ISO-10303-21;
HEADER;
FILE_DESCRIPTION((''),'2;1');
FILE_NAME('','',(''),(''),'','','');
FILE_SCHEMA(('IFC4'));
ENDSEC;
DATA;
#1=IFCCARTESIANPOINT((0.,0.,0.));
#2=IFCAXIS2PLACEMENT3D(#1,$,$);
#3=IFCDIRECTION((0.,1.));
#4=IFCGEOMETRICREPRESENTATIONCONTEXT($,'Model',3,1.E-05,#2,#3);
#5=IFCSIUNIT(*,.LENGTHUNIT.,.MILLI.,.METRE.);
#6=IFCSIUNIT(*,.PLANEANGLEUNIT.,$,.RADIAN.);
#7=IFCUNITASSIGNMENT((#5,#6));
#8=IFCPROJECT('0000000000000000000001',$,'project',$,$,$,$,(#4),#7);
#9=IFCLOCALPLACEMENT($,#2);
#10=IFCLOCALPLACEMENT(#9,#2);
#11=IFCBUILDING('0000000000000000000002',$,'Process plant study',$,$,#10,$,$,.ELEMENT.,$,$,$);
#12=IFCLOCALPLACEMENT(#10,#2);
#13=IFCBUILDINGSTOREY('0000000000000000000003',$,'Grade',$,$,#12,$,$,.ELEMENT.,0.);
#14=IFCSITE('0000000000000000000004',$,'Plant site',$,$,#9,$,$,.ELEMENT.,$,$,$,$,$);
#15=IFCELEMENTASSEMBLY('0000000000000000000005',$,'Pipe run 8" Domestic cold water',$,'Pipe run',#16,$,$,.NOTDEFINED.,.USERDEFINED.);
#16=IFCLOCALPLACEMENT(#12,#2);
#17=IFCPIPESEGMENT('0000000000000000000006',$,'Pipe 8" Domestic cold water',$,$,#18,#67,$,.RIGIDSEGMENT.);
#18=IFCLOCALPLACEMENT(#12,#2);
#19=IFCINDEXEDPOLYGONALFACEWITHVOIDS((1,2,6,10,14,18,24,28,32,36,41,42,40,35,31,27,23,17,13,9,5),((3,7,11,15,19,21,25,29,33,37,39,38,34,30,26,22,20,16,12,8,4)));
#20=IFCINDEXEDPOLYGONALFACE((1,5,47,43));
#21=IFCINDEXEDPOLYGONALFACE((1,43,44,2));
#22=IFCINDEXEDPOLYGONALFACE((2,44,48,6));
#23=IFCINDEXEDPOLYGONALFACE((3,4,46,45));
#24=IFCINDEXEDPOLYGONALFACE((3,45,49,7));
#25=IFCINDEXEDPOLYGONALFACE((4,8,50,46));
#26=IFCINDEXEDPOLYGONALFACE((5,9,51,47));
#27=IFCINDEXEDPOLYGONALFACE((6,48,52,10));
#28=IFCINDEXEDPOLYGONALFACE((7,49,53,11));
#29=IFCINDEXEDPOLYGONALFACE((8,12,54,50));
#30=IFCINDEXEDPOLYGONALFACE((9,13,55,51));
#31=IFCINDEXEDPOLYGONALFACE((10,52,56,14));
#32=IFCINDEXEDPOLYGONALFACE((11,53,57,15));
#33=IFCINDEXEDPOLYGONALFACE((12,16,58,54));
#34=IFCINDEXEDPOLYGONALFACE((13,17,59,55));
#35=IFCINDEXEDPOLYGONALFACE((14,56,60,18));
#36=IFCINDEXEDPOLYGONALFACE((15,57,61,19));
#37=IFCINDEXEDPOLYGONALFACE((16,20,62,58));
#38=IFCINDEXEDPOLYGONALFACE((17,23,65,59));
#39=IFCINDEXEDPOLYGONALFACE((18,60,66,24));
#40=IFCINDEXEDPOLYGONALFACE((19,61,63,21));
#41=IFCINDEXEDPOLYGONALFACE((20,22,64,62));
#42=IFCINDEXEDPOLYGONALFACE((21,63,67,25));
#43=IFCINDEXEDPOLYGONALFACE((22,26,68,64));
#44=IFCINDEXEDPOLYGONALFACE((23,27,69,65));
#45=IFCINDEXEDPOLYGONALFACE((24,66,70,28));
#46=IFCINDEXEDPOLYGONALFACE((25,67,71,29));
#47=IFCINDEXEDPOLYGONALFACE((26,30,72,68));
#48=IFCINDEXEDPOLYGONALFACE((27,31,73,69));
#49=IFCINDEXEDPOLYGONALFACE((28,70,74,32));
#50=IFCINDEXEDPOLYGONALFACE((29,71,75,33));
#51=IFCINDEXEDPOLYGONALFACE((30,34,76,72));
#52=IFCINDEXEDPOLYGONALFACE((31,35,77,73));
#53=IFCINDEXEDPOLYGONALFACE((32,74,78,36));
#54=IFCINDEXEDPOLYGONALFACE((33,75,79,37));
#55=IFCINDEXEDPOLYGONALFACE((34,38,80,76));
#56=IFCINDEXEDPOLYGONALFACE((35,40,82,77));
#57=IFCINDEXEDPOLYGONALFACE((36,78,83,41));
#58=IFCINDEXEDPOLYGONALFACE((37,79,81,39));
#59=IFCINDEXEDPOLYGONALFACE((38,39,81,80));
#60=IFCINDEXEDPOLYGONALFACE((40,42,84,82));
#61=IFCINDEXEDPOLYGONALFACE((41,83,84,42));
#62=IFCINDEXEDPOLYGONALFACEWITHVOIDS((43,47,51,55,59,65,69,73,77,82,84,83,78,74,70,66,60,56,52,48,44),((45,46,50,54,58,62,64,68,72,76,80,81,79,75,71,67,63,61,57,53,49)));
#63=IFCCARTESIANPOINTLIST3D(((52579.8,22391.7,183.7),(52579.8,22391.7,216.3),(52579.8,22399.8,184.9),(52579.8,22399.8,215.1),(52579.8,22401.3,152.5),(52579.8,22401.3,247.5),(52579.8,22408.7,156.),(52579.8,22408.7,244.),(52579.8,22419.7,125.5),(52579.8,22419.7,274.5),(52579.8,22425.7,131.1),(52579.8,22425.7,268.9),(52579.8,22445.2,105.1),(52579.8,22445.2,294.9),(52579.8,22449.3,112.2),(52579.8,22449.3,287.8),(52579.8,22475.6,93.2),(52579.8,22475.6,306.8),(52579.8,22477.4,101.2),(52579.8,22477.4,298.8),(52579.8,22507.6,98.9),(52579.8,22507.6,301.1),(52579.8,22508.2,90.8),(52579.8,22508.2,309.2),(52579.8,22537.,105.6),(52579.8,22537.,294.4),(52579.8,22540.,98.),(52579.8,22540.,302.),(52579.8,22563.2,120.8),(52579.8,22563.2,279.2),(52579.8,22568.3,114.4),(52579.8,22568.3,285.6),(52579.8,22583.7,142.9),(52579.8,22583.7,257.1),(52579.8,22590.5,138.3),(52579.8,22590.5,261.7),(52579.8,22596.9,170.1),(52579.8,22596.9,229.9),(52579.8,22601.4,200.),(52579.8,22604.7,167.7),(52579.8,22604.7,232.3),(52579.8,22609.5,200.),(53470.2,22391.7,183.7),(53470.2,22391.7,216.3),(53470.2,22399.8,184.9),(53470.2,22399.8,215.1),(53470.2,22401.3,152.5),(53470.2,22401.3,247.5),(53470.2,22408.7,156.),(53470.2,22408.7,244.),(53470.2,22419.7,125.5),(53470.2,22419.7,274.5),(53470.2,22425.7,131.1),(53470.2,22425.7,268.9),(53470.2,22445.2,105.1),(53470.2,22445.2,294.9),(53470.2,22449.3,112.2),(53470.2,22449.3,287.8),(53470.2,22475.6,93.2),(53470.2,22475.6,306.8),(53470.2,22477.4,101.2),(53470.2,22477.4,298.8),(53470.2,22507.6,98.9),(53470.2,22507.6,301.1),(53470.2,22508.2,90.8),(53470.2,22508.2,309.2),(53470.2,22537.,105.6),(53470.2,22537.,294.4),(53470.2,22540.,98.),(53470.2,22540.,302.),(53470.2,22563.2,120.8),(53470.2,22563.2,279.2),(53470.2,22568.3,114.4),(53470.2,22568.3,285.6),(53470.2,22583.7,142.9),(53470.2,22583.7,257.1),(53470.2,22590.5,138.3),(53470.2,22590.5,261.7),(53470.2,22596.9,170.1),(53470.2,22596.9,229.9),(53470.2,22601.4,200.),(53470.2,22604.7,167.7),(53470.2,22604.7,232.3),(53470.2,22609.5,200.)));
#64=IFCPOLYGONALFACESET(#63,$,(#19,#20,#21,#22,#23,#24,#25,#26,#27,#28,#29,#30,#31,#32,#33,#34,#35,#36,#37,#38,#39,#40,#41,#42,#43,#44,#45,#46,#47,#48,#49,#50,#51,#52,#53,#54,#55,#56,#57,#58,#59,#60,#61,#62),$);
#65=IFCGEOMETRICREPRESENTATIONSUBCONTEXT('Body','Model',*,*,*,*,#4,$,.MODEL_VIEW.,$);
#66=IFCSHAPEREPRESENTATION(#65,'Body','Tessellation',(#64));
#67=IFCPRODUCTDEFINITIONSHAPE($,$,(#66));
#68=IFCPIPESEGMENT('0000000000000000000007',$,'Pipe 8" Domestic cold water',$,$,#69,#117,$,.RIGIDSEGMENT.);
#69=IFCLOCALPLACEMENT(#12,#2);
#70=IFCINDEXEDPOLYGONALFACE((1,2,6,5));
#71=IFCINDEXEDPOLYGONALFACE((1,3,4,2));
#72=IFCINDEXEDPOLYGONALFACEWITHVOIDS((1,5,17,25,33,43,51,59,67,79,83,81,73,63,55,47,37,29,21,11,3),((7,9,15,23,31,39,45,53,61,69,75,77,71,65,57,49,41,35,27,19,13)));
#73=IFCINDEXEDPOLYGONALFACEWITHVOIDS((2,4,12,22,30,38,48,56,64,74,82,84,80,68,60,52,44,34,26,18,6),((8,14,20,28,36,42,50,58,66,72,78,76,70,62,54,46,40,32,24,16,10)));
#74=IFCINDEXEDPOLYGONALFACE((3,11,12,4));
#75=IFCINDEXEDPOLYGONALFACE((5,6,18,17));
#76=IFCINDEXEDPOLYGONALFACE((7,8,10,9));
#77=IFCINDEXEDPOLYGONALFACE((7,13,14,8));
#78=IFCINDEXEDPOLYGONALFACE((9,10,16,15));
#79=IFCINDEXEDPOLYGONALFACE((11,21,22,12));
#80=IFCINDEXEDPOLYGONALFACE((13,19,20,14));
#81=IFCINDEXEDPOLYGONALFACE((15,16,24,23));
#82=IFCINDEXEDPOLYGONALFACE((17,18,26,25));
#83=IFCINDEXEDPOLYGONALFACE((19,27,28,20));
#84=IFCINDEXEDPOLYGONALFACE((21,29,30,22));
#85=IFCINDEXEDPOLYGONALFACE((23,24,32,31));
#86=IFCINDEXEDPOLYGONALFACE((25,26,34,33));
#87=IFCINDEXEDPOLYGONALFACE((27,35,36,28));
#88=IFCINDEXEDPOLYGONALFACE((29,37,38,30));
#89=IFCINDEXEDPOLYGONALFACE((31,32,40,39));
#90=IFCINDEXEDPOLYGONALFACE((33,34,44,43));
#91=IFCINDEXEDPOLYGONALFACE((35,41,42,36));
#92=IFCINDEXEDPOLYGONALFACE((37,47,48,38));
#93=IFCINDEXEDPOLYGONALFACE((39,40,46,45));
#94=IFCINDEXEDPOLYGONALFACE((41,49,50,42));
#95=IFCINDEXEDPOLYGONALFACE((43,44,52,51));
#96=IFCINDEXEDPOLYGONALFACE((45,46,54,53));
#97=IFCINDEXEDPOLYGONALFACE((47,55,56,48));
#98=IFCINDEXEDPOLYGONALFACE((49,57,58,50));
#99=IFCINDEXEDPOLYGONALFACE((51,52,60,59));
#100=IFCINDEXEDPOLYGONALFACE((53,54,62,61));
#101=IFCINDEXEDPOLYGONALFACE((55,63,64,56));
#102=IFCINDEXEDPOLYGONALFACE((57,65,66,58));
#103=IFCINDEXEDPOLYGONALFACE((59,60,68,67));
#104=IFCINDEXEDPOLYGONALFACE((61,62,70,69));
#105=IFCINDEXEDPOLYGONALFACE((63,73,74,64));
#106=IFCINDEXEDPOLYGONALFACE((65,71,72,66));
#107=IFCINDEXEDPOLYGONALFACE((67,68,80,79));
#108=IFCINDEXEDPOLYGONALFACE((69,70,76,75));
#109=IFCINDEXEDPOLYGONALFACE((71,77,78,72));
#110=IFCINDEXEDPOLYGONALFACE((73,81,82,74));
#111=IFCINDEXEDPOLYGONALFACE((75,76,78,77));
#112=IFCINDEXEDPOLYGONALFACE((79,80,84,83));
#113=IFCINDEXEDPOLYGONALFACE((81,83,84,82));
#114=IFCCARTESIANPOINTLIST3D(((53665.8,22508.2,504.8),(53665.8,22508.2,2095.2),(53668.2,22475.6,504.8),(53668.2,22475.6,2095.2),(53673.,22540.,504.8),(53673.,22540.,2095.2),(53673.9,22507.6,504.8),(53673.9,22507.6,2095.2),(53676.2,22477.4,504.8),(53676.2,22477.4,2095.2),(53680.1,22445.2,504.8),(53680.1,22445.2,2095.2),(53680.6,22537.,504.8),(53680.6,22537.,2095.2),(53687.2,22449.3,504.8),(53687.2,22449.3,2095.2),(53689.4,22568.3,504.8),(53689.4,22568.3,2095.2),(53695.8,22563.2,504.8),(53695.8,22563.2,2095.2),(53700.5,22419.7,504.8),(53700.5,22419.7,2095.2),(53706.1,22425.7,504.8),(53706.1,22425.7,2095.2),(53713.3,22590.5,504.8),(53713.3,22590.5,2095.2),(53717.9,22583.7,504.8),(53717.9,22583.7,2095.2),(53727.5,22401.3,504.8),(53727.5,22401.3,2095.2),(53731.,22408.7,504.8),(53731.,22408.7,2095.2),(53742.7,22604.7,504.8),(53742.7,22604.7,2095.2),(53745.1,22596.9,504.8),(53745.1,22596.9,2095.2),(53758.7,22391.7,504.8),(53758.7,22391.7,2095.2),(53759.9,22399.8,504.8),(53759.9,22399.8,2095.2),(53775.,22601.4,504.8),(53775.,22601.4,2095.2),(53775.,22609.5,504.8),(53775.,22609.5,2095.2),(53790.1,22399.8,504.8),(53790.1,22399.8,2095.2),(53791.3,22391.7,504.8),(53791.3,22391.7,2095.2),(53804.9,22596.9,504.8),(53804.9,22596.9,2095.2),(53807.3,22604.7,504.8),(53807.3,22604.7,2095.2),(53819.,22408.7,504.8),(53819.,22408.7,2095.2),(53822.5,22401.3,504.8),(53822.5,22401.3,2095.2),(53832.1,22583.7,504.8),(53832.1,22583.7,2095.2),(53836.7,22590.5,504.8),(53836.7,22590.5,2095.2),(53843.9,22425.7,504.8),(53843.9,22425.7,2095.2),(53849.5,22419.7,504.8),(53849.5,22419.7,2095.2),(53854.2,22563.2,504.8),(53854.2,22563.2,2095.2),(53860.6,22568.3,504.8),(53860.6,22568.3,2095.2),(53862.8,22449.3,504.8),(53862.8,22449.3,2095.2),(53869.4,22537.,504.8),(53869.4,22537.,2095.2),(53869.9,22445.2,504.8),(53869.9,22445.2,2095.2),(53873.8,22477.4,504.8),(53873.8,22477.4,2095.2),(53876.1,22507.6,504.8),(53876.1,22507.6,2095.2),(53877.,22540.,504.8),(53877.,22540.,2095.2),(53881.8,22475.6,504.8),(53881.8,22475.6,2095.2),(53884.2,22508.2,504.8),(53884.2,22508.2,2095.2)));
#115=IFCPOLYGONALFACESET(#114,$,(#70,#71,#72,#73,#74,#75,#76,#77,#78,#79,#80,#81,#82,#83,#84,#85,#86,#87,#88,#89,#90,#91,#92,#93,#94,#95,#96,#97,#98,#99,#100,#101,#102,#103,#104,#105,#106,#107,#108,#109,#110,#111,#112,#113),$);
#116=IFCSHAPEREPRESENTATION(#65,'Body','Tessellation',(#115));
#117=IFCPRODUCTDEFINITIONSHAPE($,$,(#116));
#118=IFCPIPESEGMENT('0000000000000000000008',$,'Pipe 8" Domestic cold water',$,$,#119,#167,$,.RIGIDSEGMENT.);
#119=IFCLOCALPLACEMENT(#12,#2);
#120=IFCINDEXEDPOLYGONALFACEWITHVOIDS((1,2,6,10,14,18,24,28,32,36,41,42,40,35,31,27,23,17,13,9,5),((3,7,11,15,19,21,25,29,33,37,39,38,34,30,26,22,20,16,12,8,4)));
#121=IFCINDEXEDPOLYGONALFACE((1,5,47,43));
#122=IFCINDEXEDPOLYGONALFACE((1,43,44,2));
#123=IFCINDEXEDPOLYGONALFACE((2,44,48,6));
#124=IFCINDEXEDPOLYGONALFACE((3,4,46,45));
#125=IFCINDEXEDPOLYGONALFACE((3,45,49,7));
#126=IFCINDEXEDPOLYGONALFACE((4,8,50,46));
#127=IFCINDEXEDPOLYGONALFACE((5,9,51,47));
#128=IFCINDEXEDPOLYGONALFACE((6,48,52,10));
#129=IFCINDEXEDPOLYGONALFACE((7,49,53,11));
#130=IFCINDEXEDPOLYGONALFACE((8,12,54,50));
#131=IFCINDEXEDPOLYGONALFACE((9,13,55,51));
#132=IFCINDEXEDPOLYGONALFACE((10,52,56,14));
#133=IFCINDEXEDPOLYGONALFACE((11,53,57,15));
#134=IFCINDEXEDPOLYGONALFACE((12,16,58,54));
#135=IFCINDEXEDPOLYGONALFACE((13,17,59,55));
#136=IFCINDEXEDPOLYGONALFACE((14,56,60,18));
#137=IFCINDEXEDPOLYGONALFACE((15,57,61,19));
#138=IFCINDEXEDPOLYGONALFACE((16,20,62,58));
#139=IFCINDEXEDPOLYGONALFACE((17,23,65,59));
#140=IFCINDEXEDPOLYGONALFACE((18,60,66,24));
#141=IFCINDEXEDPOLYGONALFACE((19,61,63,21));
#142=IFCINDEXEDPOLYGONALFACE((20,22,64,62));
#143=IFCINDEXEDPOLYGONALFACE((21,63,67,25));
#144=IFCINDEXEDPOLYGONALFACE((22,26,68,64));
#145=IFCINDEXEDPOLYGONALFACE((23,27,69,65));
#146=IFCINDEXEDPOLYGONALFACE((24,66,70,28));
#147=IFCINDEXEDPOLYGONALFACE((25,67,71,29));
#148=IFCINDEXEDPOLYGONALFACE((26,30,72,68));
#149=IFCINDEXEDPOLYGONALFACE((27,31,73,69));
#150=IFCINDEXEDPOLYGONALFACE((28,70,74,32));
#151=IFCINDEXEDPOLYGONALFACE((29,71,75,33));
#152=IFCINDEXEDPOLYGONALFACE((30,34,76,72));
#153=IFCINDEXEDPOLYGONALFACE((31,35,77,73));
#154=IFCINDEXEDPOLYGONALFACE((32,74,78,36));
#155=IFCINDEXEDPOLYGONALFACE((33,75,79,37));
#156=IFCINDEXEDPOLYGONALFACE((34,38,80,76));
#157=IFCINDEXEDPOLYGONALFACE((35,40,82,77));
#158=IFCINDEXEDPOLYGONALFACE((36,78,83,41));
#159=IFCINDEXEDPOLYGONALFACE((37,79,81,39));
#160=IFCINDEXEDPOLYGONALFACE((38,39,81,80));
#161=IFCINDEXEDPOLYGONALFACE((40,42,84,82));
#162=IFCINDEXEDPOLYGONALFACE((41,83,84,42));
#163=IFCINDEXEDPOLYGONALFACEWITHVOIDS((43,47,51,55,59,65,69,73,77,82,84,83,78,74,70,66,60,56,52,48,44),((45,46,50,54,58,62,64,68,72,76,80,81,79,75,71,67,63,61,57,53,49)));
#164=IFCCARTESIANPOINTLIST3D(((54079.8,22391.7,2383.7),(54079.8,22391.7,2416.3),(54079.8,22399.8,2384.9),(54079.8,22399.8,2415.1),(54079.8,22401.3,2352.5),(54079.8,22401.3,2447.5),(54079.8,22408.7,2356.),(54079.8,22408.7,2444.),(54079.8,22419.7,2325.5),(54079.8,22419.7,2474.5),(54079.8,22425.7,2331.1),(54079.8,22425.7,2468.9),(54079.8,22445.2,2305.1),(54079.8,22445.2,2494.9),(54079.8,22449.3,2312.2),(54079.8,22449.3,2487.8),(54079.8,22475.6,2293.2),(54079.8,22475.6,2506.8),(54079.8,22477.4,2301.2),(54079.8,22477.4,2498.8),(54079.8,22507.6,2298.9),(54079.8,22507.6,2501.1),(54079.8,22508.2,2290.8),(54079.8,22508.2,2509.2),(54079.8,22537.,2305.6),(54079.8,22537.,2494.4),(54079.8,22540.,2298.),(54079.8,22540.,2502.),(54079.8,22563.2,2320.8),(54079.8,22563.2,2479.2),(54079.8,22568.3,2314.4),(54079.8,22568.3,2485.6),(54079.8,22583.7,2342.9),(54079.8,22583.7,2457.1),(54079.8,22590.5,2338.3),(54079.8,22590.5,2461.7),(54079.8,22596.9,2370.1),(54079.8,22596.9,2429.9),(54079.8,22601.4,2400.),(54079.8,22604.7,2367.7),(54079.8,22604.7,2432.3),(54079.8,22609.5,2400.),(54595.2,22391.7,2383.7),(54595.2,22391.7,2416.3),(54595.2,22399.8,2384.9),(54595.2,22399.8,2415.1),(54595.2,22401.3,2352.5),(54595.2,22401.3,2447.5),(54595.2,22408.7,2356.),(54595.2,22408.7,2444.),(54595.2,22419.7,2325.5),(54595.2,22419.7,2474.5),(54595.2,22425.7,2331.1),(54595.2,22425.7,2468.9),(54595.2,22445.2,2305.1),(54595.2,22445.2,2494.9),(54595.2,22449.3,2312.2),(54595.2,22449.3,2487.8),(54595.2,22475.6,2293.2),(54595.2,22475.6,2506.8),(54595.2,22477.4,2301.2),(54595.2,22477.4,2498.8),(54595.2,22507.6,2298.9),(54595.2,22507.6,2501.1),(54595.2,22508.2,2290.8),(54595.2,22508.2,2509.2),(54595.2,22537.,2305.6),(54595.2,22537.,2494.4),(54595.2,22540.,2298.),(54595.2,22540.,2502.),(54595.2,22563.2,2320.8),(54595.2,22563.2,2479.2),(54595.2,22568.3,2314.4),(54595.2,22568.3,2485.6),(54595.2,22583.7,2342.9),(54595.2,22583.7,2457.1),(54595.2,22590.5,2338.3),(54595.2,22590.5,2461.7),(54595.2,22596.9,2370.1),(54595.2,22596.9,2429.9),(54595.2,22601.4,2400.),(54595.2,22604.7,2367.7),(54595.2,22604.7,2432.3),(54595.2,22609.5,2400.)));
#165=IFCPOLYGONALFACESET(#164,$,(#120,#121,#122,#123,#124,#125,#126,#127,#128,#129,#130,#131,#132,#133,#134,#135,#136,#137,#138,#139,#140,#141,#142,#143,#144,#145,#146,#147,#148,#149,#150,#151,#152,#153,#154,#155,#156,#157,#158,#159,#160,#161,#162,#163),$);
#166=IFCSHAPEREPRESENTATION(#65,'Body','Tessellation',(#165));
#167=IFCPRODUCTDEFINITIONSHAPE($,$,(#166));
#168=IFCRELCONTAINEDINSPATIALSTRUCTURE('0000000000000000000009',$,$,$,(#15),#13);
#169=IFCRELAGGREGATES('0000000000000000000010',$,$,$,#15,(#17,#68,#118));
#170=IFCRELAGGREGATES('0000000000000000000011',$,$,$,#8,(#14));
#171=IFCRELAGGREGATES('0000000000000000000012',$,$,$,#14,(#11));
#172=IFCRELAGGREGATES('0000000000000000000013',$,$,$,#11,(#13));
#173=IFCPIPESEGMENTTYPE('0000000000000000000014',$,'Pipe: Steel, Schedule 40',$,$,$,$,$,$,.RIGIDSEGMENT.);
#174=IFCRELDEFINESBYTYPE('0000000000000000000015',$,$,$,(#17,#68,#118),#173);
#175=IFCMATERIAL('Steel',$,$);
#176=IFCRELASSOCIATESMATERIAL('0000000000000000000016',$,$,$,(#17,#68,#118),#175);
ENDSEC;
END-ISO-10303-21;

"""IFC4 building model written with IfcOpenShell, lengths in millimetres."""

from ifc_helpers import new_model, si_unit, direction, frame, origin, origin_with_axes, origin_2d, place, context, subcontext, project, spatial, hollow_circle, extrude, material, type_object, element, aggregate, save


model = new_model("IFC4")

# Units and contexts
model_context = context("Model", 3, precision=1e-05, world=origin(), true_north=direction((0.0, 1.0)))
body_context = subcontext(model_context, "Body", "Model", "MODEL_VIEW")
ifc_project = project(units=[si_unit("LENGTHUNIT", "METRE", prefix="MILLI"), si_unit("PLANEANGLEUNIT", "RADIAN")], contexts=[model_context])

# Site, building, storey
site_placement = place(None, origin())
site = spatial("IfcSite", under=ifc_project, at=site_placement, Name="Plant site", CompositionType="ELEMENT")
building_placement = place(site_placement, origin())
building = spatial("IfcBuilding", under=site, at=building_placement, Name="Process plant study", CompositionType="ELEMENT")
storey_placement = place(building_placement, origin())
storey = spatial("IfcBuildingStorey", under=building, at=storey_placement, Name="Grade", CompositionType="ELEMENT", Elevation=0.0)

# Element assembly, pipe segments
ifc_material = material(Name="Steel")
pipe_segment_type = type_object("IfcPipeSegmentType", Name="Pipe: Steel, Schedule 40", PredefinedType="RIGIDSEGMENT")
assembly_1_placement = place(storey_placement, origin_with_axes())
assembly_1 = element("IfcElementAssembly", 1, at=assembly_1_placement, inside=storey, Name="Pipe run 8\" Domestic cold water", ObjectType="Pipe run", AssemblyPlace="NOTDEFINED", PredefinedType="USERDEFINED")
pipe_segment_1_placement = place(storey_placement, origin_with_axes())
pipe_segment_1 = element("IfcPipeSegment", 2, at=pipe_segment_1_placement, type_object=pipe_segment_type, material=ifc_material, Name="Pipe 8\" Domestic cold water", PredefinedType="RIGIDSEGMENT", context=body_context, shape_type="SweptSolid", body=[
    extrude(hollow_circle(Radius=109.5, WallThickness=8.2, at=origin_2d()), frame((52579.8, 22500.0, 200.0), z_axis=(1.0, 0.0, 0.0), x_axis=(0.0, 1.0, 0.0)), (0.0, 0.0, 1.0), 890.4),
])
pipe_segment_2_placement = place(storey_placement, origin_with_axes())
pipe_segment_2 = element("IfcPipeSegment", 3, at=pipe_segment_2_placement, type_object=pipe_segment_type, material=ifc_material, Name="Pipe 8\" Domestic cold water", PredefinedType="RIGIDSEGMENT", context=body_context, shape_type="SweptSolid", body=[
    extrude(hollow_circle(Radius=109.5, WallThickness=8.2, at=origin_2d()), frame((53775.0, 22500.0, 504.8), z_axis=(0.0, 0.0, 1.0), x_axis=(0.0, 1.0, 0.0)), (0.0, 0.0, 1.0), 1590.4),
])
pipe_segment_3_placement = place(storey_placement, origin_with_axes())
pipe_segment_3 = element("IfcPipeSegment", 4, at=pipe_segment_3_placement, type_object=pipe_segment_type, material=ifc_material, Name="Pipe 8\" Domestic cold water", PredefinedType="RIGIDSEGMENT", context=body_context, shape_type="SweptSolid", body=[
    extrude(hollow_circle(Radius=109.5, WallThickness=8.2, at=origin_2d()), frame((54079.8, 22500.0, 2400.0), z_axis=(1.0, 0.0, 0.0), x_axis=(0.0, 1.0, 0.0)), (0.0, 0.0, 1.0), 515.4),
])

aggregate(assembly_1, [pipe_segment_1, pipe_segment_2, pipe_segment_3])

save(model, "model.ifc")
